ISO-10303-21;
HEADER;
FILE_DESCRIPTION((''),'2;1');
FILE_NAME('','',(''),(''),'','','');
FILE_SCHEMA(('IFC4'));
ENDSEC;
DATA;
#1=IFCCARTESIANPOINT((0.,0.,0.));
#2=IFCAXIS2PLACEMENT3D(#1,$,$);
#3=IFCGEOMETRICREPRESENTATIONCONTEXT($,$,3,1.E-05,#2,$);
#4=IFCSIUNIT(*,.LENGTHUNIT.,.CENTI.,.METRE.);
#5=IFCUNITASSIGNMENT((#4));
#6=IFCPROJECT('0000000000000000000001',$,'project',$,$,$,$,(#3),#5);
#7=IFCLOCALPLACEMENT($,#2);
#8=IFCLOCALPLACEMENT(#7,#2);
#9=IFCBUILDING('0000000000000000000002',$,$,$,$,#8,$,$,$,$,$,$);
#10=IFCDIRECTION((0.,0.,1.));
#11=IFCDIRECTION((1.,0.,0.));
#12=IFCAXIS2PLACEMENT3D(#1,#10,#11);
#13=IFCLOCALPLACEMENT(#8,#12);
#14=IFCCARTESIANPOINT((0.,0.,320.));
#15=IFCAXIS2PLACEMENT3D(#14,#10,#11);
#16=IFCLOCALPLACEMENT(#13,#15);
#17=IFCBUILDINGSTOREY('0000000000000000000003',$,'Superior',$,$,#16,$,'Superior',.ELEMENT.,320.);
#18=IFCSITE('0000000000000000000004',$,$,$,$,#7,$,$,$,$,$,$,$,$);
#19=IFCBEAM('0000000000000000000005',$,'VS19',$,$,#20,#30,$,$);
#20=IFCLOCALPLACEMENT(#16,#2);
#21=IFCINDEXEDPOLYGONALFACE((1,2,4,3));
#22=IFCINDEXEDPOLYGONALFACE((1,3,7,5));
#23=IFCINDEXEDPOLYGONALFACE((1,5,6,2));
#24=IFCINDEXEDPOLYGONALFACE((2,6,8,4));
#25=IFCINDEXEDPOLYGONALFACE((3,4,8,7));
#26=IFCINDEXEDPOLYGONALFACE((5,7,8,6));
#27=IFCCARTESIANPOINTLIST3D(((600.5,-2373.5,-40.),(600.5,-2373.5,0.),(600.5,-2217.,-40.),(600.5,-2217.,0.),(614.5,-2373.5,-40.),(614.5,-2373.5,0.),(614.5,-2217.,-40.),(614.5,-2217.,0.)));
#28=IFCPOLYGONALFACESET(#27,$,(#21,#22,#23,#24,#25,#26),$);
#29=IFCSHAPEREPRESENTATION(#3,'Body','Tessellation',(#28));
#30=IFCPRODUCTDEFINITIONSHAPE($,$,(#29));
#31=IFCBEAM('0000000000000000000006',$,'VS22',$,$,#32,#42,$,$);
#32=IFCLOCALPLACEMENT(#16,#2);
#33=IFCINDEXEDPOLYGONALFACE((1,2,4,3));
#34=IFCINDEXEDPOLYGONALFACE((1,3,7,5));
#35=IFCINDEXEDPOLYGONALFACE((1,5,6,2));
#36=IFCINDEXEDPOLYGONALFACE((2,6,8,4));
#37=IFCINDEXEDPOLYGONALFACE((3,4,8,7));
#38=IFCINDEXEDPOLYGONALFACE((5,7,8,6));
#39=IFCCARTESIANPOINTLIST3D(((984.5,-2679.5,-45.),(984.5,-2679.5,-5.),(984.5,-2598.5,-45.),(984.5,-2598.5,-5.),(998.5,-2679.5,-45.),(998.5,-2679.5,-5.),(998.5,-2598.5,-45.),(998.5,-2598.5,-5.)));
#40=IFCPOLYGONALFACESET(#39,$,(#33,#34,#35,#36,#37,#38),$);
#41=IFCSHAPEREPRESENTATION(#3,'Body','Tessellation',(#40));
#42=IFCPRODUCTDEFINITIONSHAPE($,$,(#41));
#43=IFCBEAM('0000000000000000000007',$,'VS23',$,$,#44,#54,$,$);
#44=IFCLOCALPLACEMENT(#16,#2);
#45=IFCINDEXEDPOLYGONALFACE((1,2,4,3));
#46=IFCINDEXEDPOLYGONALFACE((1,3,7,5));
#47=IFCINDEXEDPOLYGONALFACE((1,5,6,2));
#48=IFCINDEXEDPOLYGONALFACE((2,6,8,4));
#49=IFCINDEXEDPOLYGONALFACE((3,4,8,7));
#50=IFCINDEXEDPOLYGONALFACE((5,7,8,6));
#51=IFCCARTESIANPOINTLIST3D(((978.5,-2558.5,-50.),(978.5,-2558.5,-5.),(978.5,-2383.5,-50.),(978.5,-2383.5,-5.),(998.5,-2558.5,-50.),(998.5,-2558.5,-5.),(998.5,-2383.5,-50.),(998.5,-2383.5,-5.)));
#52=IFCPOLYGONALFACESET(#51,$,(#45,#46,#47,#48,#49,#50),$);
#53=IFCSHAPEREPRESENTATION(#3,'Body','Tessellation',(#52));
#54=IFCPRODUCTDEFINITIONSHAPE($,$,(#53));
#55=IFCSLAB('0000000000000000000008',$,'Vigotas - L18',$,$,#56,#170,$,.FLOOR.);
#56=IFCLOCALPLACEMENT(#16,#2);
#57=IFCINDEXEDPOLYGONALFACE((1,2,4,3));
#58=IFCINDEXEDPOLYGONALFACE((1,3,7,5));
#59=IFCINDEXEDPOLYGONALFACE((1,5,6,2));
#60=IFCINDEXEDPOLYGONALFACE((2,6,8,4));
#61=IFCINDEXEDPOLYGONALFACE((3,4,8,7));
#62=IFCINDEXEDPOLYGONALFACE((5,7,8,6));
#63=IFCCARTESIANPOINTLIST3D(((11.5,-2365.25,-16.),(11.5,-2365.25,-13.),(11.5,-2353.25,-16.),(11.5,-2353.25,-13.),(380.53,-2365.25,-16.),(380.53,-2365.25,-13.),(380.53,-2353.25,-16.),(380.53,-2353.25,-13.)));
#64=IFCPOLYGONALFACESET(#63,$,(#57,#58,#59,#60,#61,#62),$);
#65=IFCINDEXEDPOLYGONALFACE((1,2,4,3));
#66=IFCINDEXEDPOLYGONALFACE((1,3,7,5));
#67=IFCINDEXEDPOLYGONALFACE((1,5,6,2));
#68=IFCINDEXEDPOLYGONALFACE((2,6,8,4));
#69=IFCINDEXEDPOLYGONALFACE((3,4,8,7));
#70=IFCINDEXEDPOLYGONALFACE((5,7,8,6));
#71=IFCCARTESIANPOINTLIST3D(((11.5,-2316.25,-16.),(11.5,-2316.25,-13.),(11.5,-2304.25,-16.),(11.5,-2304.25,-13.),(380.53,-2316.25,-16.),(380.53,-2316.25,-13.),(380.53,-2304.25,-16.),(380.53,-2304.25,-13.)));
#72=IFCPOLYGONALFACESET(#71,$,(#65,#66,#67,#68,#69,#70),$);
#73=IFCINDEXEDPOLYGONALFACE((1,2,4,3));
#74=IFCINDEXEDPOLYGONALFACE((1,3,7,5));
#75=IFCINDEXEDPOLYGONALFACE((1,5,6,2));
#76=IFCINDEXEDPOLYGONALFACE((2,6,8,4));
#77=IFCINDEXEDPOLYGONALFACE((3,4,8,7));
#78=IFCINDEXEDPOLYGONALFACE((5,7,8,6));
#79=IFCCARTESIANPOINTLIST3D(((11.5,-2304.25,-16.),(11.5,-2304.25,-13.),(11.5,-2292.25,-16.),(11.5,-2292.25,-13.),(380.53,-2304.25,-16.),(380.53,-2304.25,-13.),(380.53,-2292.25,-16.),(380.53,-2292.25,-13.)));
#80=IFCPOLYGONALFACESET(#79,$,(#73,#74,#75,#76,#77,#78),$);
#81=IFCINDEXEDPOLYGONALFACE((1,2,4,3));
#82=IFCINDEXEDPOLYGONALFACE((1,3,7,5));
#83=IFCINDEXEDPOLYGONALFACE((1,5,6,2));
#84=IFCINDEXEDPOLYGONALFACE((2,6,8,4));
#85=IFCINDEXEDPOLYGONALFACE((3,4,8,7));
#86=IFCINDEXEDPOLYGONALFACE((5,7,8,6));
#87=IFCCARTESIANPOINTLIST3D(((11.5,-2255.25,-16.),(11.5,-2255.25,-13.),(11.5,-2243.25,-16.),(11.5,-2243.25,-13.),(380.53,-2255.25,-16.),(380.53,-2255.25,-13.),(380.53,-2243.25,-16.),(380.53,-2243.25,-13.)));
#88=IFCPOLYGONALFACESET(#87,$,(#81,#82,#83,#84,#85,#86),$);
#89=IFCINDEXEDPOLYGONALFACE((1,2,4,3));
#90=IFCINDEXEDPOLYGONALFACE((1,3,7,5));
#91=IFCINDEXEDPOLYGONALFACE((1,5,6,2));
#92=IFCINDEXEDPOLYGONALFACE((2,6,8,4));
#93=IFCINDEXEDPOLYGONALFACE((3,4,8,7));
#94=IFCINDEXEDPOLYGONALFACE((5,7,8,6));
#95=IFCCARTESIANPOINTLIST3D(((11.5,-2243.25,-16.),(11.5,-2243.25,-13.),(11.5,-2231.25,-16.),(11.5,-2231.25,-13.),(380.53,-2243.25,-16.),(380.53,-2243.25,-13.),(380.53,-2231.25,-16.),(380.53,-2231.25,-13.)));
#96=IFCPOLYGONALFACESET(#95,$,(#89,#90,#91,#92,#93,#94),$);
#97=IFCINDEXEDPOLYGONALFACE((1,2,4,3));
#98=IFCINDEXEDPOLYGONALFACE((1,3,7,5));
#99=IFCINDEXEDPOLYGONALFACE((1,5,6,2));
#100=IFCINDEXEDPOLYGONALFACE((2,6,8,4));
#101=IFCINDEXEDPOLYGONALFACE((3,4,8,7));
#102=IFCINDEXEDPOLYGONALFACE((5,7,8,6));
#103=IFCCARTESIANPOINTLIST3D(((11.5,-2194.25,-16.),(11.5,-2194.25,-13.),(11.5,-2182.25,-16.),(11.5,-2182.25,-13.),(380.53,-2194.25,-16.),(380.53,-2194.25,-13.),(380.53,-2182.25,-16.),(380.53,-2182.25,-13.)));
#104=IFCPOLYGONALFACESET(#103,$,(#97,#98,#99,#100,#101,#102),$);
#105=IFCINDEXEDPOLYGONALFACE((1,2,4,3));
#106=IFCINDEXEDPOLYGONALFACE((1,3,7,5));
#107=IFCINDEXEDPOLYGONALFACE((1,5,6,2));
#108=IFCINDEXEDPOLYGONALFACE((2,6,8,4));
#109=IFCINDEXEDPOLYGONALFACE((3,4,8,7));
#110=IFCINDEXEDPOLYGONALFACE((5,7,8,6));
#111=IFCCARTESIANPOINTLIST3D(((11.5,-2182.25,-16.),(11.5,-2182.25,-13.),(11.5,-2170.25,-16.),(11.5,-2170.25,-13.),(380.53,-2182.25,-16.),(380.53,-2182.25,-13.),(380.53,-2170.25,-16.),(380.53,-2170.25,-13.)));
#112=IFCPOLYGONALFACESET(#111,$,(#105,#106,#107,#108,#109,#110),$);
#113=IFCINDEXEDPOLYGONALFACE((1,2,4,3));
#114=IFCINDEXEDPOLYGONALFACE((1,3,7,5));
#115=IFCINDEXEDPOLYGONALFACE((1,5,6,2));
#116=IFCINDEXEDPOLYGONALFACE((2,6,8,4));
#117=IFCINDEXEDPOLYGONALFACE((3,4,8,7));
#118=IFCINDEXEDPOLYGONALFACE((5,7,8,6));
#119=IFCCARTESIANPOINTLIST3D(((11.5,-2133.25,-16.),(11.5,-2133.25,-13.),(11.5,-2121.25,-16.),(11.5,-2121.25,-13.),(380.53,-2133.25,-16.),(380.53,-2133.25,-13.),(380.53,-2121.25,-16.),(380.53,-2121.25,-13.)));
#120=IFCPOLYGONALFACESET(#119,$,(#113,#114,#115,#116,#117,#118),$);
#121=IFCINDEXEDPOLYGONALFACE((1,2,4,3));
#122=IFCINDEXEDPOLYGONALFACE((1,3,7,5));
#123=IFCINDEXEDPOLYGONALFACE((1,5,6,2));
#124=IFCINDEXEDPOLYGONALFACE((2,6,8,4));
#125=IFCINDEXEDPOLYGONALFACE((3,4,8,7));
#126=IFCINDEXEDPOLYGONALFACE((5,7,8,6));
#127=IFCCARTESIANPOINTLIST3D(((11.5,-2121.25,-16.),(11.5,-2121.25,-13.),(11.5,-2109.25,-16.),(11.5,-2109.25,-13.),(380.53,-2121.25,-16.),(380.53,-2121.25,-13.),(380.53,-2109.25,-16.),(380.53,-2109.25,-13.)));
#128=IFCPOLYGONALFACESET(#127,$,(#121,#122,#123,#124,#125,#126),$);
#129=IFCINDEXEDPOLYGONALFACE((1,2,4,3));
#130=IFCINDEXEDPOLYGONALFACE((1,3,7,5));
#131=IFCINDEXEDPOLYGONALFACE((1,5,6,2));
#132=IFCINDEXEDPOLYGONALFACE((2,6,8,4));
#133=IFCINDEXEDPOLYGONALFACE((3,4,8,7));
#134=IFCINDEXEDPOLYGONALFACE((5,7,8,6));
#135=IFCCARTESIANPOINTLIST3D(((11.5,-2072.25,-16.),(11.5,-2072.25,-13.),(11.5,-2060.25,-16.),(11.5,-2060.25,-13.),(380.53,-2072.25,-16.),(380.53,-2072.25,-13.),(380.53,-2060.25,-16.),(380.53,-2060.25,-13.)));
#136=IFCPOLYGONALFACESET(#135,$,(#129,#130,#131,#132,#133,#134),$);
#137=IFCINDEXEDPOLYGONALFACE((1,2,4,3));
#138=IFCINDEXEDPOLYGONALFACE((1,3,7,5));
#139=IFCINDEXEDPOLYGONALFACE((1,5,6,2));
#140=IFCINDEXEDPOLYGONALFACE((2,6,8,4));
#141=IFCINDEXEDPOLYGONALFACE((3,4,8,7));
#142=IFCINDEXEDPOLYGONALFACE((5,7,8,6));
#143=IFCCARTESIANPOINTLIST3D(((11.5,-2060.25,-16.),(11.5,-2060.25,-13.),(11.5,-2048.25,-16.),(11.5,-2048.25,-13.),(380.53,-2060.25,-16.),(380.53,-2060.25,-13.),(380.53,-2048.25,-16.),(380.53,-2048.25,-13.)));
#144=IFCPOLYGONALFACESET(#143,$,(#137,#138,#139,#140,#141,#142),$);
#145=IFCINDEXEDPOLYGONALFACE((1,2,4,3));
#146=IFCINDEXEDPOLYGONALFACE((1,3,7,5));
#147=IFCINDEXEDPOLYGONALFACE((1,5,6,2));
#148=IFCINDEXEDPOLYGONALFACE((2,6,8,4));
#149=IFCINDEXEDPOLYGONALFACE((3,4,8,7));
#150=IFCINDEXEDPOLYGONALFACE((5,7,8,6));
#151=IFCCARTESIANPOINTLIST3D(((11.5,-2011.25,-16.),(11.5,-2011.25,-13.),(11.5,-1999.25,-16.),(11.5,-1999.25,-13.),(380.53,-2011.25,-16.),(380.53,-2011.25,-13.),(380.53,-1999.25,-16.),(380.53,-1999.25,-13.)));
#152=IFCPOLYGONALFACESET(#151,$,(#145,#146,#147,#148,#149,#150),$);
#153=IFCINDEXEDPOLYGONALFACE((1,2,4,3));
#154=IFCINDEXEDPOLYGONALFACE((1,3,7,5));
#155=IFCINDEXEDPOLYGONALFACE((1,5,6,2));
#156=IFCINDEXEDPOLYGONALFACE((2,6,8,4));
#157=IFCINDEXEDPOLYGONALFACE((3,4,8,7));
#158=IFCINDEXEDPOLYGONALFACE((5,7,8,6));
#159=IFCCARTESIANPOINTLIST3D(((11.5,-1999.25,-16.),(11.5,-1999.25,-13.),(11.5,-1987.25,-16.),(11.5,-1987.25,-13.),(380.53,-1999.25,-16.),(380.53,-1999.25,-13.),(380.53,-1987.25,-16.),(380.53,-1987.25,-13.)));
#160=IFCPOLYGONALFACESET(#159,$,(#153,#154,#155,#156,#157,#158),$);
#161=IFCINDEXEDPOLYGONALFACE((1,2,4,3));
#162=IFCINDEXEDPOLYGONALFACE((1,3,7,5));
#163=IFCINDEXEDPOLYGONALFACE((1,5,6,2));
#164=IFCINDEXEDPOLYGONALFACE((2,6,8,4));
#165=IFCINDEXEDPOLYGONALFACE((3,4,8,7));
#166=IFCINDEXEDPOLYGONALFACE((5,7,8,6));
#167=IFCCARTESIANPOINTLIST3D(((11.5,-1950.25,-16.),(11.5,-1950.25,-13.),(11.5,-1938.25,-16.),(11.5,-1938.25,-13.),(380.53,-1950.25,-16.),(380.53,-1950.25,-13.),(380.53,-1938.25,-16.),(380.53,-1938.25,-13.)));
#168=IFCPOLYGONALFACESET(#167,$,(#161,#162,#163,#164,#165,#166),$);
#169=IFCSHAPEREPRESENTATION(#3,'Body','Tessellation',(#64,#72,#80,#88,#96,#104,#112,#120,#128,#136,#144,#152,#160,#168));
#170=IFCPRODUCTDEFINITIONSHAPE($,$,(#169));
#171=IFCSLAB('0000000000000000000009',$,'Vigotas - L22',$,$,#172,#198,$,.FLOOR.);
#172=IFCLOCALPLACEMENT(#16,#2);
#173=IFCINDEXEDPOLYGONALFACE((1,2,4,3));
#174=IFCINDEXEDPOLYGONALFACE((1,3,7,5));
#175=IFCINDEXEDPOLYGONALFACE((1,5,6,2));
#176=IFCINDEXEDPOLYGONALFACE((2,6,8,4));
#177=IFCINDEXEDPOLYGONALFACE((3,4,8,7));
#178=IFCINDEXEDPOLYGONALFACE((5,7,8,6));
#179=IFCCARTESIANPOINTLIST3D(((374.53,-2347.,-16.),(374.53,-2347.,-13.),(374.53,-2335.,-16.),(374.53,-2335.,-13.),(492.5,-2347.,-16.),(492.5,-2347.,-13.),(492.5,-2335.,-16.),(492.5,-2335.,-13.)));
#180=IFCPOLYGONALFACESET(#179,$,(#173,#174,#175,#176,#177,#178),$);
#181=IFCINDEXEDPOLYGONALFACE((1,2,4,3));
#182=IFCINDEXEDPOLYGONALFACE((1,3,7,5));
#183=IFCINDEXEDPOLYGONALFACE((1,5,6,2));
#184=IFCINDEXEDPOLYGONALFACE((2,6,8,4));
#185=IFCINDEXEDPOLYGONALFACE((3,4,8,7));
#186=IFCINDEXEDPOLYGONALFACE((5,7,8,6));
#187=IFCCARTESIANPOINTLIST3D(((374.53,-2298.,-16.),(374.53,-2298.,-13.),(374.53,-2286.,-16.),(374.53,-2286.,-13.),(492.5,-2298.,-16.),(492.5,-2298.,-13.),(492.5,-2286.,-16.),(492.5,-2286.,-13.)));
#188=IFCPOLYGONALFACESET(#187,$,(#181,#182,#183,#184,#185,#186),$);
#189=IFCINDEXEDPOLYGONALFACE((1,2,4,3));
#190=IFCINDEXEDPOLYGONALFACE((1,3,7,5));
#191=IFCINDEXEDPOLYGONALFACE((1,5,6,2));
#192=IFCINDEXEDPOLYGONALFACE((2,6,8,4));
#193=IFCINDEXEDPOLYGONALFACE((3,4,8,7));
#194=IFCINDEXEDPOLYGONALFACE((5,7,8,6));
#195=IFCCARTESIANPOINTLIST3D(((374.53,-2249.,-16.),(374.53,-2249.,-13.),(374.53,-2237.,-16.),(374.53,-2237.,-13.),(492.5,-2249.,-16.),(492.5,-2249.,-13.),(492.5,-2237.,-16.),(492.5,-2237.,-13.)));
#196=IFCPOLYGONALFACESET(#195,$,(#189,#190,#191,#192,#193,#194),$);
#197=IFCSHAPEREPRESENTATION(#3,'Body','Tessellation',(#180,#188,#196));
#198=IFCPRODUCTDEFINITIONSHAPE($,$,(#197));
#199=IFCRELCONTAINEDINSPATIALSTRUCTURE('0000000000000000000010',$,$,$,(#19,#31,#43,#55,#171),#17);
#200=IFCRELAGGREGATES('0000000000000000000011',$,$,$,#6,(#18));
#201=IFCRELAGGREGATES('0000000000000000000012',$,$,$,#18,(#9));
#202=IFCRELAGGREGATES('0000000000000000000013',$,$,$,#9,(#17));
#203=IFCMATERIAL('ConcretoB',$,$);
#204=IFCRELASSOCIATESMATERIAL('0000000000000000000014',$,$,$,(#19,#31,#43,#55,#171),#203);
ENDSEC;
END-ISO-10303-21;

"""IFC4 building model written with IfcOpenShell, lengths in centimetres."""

from ifc_helpers import new_model, si_unit, frame, origin, origin_with_axes, place, context, project, spatial, polyline, outline, extrude, material, element, save


model = new_model("IFC4")

# Units and contexts
context_of_model = context(None, 3, precision=1e-05, world=origin())
ifc_project = project(units=[si_unit("LENGTHUNIT", "METRE", prefix="CENTI")], contexts=[context_of_model])

# Site, building, storey
site_placement = place(None, origin())
site = spatial("IfcSite", under=ifc_project, at=site_placement)
building_placement = place(site_placement, origin())
building = spatial("IfcBuilding", under=site, at=building_placement)
placement = place(building_placement, origin_with_axes())
storey_placement = place(placement, frame((0.0, 0.0, 320.0), z_axis=(0.0, 0.0, 1.0), x_axis=(1.0, 0.0, 0.0)))
storey = spatial("IfcBuildingStorey", under=building, at=storey_placement, Name="Superior", LongName="Superior", CompositionType="ELEMENT", Elevation=320.0)

# Shared definitions
ifc_material = material(Name="ConcretoB")

# Beams
beam_1_placement = place(storey_placement, frame((607.5, -2295.25, 0.0), z_axis=(0.0, 0.0, 1.0), x_axis=(1.0, 0.0, 0.0)))
element("IfcBeam", 1, at=beam_1_placement, inside=storey, material=ifc_material, Name="VS19", context=context_of_model, shape_type="SolidModel", body=[
    extrude(outline(polyline([(-7.0, -20.0), (7.0, -20.0), (7.0, 20.0), (-7.0, 20.0), (-7.0, -20.0)])), frame((0.0, -78.25, -20.0), z_axis=(0.0, 1.0, 0.0), x_axis=(1.0, 0.0, 0.0)), (0.0, 0.0, 1.0), 156.5),
])
beam_2_placement = place(storey_placement, frame((991.5, -2639.0, -5.0), z_axis=(0.0, 0.0, 1.0), x_axis=(1.0, 0.0, 0.0)))
element("IfcBeam", 2, at=beam_2_placement, inside=storey, material=ifc_material, Name="VS22", context=context_of_model, shape_type="SolidModel", body=[
    extrude(outline(polyline([(-7.0, -20.0), (7.0, -20.0), (7.0, 20.0), (-7.0, 20.0), (-7.0, -20.0)])), frame((0.0, -40.5, -20.0), z_axis=(0.0, 1.0, 0.0), x_axis=(1.0, 0.0, 0.0)), (0.0, 0.0, 1.0), 81.0),
])
beam_3_placement = place(storey_placement, frame((988.5, -2471.0, -5.0), z_axis=(0.0, 0.0, 1.0), x_axis=(1.0, 0.0, 0.0)))
element("IfcBeam", 3, at=beam_3_placement, inside=storey, material=ifc_material, Name="VS23", context=context_of_model, shape_type="SolidModel", body=[
    extrude(outline(polyline([(-10.0, -22.5), (10.0, -22.5), (10.0, 22.5), (-10.0, 22.5), (-10.0, -22.5)])), frame((0.0, -87.5, -22.5), z_axis=(0.0, 1.0, 0.0), x_axis=(1.0, 0.0, 0.0)), (0.0, 0.0, 1.0), 175.0),
])

# Slabs
slab_1_placement = place(storey_placement, frame((196.01, -2151.75, -13.0), z_axis=(0.0, 0.0, 1.0), x_axis=(1.0, 0.0, 0.0)))
element("IfcSlab", 4, at=slab_1_placement, inside=storey, material=ifc_material, Name="Vigotas - L18", PredefinedType="FLOOR", context=context_of_model, shape_type="SolidModel", body=[
    extrude(outline(polyline([(6.0, 1.5), (-6.0, 1.5), (-6.0, -1.5), (6.0, -1.5), (6.0, 1.5), (6.0, 1.5)])), frame((-184.51, -207.5, -1.5), z_axis=(1.0, 0.0, 0.0), x_axis=(0.0, -1.0, 0.0)), (0.0, 0.0, 1.0), 369.03),
    extrude(outline(polyline([(6.0, 1.5), (-6.0, 1.5), (-6.0, -1.5), (6.0, -1.5), (6.0, 1.5), (6.0, 1.5)])), frame((-184.51, -158.5, -1.5), z_axis=(1.0, 0.0, 0.0), x_axis=(0.0, -1.0, 0.0)), (0.0, 0.0, 1.0), 369.03),
    extrude(outline(polyline([(6.0, 1.5), (-6.0, 1.5), (-6.0, -1.5), (6.0, -1.5), (6.0, 1.5), (6.0, 1.5)])), frame((-184.51, -146.5, -1.5), z_axis=(1.0, 0.0, 0.0), x_axis=(0.0, -1.0, 0.0)), (0.0, 0.0, 1.0), 369.03),
    extrude(outline(polyline([(6.0, 1.5), (-6.0, 1.5), (-6.0, -1.5), (6.0, -1.5), (6.0, 1.5), (6.0, 1.5)])), frame((-184.51, -97.5, -1.5), z_axis=(1.0, 0.0, 0.0), x_axis=(0.0, -1.0, 0.0)), (0.0, 0.0, 1.0), 369.03),
    extrude(outline(polyline([(6.0, 1.5), (-6.0, 1.5), (-6.0, -1.5), (6.0, -1.5), (6.0, 1.5), (6.0, 1.5)])), frame((-184.51, -85.5, -1.5), z_axis=(1.0, 0.0, 0.0), x_axis=(0.0, -1.0, 0.0)), (0.0, 0.0, 1.0), 369.03),
    extrude(outline(polyline([(6.0, 1.5), (-6.0, 1.5), (-6.0, -1.5), (6.0, -1.5), (6.0, 1.5), (6.0, 1.5)])), frame((-184.51, -36.5, -1.5), z_axis=(1.0, 0.0, 0.0), x_axis=(0.0, -1.0, 0.0)), (0.0, 0.0, 1.0), 369.03),
    extrude(outline(polyline([(6.0, 1.5), (-6.0, 1.5), (-6.0, -1.5), (6.0, -1.5), (6.0, 1.5), (6.0, 1.5)])), frame((-184.51, -24.5, -1.5), z_axis=(1.0, 0.0, 0.0), x_axis=(0.0, -1.0, 0.0)), (0.0, 0.0, 1.0), 369.03),
    extrude(outline(polyline([(6.0, 1.5), (-6.0, 1.5), (-6.0, -1.5), (6.0, -1.5), (6.0, 1.5), (6.0, 1.5)])), frame((-184.51, 24.5, -1.5), z_axis=(1.0, 0.0, 0.0), x_axis=(0.0, -1.0, 0.0)), (0.0, 0.0, 1.0), 369.03),
    extrude(outline(polyline([(6.0, 1.5), (-6.0, 1.5), (-6.0, -1.5), (6.0, -1.5), (6.0, 1.5), (6.0, 1.5)])), frame((-184.51, 36.5, -1.5), z_axis=(1.0, 0.0, 0.0), x_axis=(0.0, -1.0, 0.0)), (0.0, 0.0, 1.0), 369.03),
    extrude(outline(polyline([(6.0, 1.5), (-6.0, 1.5), (-6.0, -1.5), (6.0, -1.5), (6.0, 1.5), (6.0, 1.5)])), frame((-184.51, 85.5, -1.5), z_axis=(1.0, 0.0, 0.0), x_axis=(0.0, -1.0, 0.0)), (0.0, 0.0, 1.0), 369.03),
    extrude(outline(polyline([(6.0, 1.5), (-6.0, 1.5), (-6.0, -1.5), (6.0, -1.5), (6.0, 1.5), (6.0, 1.5)])), frame((-184.51, 97.5, -1.5), z_axis=(1.0, 0.0, 0.0), x_axis=(0.0, -1.0, 0.0)), (0.0, 0.0, 1.0), 369.03),
    extrude(outline(polyline([(6.0, 1.5), (-6.0, 1.5), (-6.0, -1.5), (6.0, -1.5), (6.0, 1.5), (6.0, 1.5)])), frame((-184.51, 146.5, -1.5), z_axis=(1.0, 0.0, 0.0), x_axis=(0.0, -1.0, 0.0)), (0.0, 0.0, 1.0), 369.03),
    extrude(outline(polyline([(6.0, 1.5), (-6.0, 1.5), (-6.0, -1.5), (6.0, -1.5), (6.0, 1.5), (6.0, 1.5)])), frame((-184.51, 158.5, -1.5), z_axis=(1.0, 0.0, 0.0), x_axis=(0.0, -1.0, 0.0)), (0.0, 0.0, 1.0), 369.03),
    extrude(outline(polyline([(6.0, 1.5), (-6.0, 1.5), (-6.0, -1.5), (6.0, -1.5), (6.0, 1.5), (6.0, 1.5)])), frame((-184.51, 207.5, -1.5), z_axis=(1.0, 0.0, 0.0), x_axis=(0.0, -1.0, 0.0)), (0.0, 0.0, 1.0), 369.03),
])
slab_2_placement = place(storey_placement, frame((433.51, -2292.0, -13.0), z_axis=(0.0, 0.0, 1.0), x_axis=(1.0, 0.0, 0.0)))
element("IfcSlab", 5, at=slab_2_placement, inside=storey, material=ifc_material, Name="Vigotas - L22", PredefinedType="FLOOR", context=context_of_model, shape_type="SolidModel", body=[
    extrude(outline(polyline([(6.0, 1.5), (-6.0, 1.5), (-6.0, -1.5), (6.0, -1.5), (6.0, 1.5), (6.0, 1.5)])), frame((-58.98, -49.0, -1.5), z_axis=(1.0, 0.0, 0.0), x_axis=(0.0, -1.0, 0.0)), (0.0, 0.0, 1.0), 117.97),
    extrude(outline(polyline([(6.0, 1.5), (-6.0, 1.5), (-6.0, -1.5), (6.0, -1.5), (6.0, 1.5), (6.0, 1.5)])), frame((-58.98, 0.0, -1.5), z_axis=(1.0, 0.0, 0.0), x_axis=(0.0, -1.0, 0.0)), (0.0, 0.0, 1.0), 117.97),
    extrude(outline(polyline([(6.0, 1.5), (-6.0, 1.5), (-6.0, -1.5), (6.0, -1.5), (6.0, 1.5), (6.0, 1.5)])), frame((-58.98, 49.0, -1.5), z_axis=(1.0, 0.0, 0.0), x_axis=(0.0, -1.0, 0.0)), (0.0, 0.0, 1.0), 117.97),
])

save(model, "model.ifc")
